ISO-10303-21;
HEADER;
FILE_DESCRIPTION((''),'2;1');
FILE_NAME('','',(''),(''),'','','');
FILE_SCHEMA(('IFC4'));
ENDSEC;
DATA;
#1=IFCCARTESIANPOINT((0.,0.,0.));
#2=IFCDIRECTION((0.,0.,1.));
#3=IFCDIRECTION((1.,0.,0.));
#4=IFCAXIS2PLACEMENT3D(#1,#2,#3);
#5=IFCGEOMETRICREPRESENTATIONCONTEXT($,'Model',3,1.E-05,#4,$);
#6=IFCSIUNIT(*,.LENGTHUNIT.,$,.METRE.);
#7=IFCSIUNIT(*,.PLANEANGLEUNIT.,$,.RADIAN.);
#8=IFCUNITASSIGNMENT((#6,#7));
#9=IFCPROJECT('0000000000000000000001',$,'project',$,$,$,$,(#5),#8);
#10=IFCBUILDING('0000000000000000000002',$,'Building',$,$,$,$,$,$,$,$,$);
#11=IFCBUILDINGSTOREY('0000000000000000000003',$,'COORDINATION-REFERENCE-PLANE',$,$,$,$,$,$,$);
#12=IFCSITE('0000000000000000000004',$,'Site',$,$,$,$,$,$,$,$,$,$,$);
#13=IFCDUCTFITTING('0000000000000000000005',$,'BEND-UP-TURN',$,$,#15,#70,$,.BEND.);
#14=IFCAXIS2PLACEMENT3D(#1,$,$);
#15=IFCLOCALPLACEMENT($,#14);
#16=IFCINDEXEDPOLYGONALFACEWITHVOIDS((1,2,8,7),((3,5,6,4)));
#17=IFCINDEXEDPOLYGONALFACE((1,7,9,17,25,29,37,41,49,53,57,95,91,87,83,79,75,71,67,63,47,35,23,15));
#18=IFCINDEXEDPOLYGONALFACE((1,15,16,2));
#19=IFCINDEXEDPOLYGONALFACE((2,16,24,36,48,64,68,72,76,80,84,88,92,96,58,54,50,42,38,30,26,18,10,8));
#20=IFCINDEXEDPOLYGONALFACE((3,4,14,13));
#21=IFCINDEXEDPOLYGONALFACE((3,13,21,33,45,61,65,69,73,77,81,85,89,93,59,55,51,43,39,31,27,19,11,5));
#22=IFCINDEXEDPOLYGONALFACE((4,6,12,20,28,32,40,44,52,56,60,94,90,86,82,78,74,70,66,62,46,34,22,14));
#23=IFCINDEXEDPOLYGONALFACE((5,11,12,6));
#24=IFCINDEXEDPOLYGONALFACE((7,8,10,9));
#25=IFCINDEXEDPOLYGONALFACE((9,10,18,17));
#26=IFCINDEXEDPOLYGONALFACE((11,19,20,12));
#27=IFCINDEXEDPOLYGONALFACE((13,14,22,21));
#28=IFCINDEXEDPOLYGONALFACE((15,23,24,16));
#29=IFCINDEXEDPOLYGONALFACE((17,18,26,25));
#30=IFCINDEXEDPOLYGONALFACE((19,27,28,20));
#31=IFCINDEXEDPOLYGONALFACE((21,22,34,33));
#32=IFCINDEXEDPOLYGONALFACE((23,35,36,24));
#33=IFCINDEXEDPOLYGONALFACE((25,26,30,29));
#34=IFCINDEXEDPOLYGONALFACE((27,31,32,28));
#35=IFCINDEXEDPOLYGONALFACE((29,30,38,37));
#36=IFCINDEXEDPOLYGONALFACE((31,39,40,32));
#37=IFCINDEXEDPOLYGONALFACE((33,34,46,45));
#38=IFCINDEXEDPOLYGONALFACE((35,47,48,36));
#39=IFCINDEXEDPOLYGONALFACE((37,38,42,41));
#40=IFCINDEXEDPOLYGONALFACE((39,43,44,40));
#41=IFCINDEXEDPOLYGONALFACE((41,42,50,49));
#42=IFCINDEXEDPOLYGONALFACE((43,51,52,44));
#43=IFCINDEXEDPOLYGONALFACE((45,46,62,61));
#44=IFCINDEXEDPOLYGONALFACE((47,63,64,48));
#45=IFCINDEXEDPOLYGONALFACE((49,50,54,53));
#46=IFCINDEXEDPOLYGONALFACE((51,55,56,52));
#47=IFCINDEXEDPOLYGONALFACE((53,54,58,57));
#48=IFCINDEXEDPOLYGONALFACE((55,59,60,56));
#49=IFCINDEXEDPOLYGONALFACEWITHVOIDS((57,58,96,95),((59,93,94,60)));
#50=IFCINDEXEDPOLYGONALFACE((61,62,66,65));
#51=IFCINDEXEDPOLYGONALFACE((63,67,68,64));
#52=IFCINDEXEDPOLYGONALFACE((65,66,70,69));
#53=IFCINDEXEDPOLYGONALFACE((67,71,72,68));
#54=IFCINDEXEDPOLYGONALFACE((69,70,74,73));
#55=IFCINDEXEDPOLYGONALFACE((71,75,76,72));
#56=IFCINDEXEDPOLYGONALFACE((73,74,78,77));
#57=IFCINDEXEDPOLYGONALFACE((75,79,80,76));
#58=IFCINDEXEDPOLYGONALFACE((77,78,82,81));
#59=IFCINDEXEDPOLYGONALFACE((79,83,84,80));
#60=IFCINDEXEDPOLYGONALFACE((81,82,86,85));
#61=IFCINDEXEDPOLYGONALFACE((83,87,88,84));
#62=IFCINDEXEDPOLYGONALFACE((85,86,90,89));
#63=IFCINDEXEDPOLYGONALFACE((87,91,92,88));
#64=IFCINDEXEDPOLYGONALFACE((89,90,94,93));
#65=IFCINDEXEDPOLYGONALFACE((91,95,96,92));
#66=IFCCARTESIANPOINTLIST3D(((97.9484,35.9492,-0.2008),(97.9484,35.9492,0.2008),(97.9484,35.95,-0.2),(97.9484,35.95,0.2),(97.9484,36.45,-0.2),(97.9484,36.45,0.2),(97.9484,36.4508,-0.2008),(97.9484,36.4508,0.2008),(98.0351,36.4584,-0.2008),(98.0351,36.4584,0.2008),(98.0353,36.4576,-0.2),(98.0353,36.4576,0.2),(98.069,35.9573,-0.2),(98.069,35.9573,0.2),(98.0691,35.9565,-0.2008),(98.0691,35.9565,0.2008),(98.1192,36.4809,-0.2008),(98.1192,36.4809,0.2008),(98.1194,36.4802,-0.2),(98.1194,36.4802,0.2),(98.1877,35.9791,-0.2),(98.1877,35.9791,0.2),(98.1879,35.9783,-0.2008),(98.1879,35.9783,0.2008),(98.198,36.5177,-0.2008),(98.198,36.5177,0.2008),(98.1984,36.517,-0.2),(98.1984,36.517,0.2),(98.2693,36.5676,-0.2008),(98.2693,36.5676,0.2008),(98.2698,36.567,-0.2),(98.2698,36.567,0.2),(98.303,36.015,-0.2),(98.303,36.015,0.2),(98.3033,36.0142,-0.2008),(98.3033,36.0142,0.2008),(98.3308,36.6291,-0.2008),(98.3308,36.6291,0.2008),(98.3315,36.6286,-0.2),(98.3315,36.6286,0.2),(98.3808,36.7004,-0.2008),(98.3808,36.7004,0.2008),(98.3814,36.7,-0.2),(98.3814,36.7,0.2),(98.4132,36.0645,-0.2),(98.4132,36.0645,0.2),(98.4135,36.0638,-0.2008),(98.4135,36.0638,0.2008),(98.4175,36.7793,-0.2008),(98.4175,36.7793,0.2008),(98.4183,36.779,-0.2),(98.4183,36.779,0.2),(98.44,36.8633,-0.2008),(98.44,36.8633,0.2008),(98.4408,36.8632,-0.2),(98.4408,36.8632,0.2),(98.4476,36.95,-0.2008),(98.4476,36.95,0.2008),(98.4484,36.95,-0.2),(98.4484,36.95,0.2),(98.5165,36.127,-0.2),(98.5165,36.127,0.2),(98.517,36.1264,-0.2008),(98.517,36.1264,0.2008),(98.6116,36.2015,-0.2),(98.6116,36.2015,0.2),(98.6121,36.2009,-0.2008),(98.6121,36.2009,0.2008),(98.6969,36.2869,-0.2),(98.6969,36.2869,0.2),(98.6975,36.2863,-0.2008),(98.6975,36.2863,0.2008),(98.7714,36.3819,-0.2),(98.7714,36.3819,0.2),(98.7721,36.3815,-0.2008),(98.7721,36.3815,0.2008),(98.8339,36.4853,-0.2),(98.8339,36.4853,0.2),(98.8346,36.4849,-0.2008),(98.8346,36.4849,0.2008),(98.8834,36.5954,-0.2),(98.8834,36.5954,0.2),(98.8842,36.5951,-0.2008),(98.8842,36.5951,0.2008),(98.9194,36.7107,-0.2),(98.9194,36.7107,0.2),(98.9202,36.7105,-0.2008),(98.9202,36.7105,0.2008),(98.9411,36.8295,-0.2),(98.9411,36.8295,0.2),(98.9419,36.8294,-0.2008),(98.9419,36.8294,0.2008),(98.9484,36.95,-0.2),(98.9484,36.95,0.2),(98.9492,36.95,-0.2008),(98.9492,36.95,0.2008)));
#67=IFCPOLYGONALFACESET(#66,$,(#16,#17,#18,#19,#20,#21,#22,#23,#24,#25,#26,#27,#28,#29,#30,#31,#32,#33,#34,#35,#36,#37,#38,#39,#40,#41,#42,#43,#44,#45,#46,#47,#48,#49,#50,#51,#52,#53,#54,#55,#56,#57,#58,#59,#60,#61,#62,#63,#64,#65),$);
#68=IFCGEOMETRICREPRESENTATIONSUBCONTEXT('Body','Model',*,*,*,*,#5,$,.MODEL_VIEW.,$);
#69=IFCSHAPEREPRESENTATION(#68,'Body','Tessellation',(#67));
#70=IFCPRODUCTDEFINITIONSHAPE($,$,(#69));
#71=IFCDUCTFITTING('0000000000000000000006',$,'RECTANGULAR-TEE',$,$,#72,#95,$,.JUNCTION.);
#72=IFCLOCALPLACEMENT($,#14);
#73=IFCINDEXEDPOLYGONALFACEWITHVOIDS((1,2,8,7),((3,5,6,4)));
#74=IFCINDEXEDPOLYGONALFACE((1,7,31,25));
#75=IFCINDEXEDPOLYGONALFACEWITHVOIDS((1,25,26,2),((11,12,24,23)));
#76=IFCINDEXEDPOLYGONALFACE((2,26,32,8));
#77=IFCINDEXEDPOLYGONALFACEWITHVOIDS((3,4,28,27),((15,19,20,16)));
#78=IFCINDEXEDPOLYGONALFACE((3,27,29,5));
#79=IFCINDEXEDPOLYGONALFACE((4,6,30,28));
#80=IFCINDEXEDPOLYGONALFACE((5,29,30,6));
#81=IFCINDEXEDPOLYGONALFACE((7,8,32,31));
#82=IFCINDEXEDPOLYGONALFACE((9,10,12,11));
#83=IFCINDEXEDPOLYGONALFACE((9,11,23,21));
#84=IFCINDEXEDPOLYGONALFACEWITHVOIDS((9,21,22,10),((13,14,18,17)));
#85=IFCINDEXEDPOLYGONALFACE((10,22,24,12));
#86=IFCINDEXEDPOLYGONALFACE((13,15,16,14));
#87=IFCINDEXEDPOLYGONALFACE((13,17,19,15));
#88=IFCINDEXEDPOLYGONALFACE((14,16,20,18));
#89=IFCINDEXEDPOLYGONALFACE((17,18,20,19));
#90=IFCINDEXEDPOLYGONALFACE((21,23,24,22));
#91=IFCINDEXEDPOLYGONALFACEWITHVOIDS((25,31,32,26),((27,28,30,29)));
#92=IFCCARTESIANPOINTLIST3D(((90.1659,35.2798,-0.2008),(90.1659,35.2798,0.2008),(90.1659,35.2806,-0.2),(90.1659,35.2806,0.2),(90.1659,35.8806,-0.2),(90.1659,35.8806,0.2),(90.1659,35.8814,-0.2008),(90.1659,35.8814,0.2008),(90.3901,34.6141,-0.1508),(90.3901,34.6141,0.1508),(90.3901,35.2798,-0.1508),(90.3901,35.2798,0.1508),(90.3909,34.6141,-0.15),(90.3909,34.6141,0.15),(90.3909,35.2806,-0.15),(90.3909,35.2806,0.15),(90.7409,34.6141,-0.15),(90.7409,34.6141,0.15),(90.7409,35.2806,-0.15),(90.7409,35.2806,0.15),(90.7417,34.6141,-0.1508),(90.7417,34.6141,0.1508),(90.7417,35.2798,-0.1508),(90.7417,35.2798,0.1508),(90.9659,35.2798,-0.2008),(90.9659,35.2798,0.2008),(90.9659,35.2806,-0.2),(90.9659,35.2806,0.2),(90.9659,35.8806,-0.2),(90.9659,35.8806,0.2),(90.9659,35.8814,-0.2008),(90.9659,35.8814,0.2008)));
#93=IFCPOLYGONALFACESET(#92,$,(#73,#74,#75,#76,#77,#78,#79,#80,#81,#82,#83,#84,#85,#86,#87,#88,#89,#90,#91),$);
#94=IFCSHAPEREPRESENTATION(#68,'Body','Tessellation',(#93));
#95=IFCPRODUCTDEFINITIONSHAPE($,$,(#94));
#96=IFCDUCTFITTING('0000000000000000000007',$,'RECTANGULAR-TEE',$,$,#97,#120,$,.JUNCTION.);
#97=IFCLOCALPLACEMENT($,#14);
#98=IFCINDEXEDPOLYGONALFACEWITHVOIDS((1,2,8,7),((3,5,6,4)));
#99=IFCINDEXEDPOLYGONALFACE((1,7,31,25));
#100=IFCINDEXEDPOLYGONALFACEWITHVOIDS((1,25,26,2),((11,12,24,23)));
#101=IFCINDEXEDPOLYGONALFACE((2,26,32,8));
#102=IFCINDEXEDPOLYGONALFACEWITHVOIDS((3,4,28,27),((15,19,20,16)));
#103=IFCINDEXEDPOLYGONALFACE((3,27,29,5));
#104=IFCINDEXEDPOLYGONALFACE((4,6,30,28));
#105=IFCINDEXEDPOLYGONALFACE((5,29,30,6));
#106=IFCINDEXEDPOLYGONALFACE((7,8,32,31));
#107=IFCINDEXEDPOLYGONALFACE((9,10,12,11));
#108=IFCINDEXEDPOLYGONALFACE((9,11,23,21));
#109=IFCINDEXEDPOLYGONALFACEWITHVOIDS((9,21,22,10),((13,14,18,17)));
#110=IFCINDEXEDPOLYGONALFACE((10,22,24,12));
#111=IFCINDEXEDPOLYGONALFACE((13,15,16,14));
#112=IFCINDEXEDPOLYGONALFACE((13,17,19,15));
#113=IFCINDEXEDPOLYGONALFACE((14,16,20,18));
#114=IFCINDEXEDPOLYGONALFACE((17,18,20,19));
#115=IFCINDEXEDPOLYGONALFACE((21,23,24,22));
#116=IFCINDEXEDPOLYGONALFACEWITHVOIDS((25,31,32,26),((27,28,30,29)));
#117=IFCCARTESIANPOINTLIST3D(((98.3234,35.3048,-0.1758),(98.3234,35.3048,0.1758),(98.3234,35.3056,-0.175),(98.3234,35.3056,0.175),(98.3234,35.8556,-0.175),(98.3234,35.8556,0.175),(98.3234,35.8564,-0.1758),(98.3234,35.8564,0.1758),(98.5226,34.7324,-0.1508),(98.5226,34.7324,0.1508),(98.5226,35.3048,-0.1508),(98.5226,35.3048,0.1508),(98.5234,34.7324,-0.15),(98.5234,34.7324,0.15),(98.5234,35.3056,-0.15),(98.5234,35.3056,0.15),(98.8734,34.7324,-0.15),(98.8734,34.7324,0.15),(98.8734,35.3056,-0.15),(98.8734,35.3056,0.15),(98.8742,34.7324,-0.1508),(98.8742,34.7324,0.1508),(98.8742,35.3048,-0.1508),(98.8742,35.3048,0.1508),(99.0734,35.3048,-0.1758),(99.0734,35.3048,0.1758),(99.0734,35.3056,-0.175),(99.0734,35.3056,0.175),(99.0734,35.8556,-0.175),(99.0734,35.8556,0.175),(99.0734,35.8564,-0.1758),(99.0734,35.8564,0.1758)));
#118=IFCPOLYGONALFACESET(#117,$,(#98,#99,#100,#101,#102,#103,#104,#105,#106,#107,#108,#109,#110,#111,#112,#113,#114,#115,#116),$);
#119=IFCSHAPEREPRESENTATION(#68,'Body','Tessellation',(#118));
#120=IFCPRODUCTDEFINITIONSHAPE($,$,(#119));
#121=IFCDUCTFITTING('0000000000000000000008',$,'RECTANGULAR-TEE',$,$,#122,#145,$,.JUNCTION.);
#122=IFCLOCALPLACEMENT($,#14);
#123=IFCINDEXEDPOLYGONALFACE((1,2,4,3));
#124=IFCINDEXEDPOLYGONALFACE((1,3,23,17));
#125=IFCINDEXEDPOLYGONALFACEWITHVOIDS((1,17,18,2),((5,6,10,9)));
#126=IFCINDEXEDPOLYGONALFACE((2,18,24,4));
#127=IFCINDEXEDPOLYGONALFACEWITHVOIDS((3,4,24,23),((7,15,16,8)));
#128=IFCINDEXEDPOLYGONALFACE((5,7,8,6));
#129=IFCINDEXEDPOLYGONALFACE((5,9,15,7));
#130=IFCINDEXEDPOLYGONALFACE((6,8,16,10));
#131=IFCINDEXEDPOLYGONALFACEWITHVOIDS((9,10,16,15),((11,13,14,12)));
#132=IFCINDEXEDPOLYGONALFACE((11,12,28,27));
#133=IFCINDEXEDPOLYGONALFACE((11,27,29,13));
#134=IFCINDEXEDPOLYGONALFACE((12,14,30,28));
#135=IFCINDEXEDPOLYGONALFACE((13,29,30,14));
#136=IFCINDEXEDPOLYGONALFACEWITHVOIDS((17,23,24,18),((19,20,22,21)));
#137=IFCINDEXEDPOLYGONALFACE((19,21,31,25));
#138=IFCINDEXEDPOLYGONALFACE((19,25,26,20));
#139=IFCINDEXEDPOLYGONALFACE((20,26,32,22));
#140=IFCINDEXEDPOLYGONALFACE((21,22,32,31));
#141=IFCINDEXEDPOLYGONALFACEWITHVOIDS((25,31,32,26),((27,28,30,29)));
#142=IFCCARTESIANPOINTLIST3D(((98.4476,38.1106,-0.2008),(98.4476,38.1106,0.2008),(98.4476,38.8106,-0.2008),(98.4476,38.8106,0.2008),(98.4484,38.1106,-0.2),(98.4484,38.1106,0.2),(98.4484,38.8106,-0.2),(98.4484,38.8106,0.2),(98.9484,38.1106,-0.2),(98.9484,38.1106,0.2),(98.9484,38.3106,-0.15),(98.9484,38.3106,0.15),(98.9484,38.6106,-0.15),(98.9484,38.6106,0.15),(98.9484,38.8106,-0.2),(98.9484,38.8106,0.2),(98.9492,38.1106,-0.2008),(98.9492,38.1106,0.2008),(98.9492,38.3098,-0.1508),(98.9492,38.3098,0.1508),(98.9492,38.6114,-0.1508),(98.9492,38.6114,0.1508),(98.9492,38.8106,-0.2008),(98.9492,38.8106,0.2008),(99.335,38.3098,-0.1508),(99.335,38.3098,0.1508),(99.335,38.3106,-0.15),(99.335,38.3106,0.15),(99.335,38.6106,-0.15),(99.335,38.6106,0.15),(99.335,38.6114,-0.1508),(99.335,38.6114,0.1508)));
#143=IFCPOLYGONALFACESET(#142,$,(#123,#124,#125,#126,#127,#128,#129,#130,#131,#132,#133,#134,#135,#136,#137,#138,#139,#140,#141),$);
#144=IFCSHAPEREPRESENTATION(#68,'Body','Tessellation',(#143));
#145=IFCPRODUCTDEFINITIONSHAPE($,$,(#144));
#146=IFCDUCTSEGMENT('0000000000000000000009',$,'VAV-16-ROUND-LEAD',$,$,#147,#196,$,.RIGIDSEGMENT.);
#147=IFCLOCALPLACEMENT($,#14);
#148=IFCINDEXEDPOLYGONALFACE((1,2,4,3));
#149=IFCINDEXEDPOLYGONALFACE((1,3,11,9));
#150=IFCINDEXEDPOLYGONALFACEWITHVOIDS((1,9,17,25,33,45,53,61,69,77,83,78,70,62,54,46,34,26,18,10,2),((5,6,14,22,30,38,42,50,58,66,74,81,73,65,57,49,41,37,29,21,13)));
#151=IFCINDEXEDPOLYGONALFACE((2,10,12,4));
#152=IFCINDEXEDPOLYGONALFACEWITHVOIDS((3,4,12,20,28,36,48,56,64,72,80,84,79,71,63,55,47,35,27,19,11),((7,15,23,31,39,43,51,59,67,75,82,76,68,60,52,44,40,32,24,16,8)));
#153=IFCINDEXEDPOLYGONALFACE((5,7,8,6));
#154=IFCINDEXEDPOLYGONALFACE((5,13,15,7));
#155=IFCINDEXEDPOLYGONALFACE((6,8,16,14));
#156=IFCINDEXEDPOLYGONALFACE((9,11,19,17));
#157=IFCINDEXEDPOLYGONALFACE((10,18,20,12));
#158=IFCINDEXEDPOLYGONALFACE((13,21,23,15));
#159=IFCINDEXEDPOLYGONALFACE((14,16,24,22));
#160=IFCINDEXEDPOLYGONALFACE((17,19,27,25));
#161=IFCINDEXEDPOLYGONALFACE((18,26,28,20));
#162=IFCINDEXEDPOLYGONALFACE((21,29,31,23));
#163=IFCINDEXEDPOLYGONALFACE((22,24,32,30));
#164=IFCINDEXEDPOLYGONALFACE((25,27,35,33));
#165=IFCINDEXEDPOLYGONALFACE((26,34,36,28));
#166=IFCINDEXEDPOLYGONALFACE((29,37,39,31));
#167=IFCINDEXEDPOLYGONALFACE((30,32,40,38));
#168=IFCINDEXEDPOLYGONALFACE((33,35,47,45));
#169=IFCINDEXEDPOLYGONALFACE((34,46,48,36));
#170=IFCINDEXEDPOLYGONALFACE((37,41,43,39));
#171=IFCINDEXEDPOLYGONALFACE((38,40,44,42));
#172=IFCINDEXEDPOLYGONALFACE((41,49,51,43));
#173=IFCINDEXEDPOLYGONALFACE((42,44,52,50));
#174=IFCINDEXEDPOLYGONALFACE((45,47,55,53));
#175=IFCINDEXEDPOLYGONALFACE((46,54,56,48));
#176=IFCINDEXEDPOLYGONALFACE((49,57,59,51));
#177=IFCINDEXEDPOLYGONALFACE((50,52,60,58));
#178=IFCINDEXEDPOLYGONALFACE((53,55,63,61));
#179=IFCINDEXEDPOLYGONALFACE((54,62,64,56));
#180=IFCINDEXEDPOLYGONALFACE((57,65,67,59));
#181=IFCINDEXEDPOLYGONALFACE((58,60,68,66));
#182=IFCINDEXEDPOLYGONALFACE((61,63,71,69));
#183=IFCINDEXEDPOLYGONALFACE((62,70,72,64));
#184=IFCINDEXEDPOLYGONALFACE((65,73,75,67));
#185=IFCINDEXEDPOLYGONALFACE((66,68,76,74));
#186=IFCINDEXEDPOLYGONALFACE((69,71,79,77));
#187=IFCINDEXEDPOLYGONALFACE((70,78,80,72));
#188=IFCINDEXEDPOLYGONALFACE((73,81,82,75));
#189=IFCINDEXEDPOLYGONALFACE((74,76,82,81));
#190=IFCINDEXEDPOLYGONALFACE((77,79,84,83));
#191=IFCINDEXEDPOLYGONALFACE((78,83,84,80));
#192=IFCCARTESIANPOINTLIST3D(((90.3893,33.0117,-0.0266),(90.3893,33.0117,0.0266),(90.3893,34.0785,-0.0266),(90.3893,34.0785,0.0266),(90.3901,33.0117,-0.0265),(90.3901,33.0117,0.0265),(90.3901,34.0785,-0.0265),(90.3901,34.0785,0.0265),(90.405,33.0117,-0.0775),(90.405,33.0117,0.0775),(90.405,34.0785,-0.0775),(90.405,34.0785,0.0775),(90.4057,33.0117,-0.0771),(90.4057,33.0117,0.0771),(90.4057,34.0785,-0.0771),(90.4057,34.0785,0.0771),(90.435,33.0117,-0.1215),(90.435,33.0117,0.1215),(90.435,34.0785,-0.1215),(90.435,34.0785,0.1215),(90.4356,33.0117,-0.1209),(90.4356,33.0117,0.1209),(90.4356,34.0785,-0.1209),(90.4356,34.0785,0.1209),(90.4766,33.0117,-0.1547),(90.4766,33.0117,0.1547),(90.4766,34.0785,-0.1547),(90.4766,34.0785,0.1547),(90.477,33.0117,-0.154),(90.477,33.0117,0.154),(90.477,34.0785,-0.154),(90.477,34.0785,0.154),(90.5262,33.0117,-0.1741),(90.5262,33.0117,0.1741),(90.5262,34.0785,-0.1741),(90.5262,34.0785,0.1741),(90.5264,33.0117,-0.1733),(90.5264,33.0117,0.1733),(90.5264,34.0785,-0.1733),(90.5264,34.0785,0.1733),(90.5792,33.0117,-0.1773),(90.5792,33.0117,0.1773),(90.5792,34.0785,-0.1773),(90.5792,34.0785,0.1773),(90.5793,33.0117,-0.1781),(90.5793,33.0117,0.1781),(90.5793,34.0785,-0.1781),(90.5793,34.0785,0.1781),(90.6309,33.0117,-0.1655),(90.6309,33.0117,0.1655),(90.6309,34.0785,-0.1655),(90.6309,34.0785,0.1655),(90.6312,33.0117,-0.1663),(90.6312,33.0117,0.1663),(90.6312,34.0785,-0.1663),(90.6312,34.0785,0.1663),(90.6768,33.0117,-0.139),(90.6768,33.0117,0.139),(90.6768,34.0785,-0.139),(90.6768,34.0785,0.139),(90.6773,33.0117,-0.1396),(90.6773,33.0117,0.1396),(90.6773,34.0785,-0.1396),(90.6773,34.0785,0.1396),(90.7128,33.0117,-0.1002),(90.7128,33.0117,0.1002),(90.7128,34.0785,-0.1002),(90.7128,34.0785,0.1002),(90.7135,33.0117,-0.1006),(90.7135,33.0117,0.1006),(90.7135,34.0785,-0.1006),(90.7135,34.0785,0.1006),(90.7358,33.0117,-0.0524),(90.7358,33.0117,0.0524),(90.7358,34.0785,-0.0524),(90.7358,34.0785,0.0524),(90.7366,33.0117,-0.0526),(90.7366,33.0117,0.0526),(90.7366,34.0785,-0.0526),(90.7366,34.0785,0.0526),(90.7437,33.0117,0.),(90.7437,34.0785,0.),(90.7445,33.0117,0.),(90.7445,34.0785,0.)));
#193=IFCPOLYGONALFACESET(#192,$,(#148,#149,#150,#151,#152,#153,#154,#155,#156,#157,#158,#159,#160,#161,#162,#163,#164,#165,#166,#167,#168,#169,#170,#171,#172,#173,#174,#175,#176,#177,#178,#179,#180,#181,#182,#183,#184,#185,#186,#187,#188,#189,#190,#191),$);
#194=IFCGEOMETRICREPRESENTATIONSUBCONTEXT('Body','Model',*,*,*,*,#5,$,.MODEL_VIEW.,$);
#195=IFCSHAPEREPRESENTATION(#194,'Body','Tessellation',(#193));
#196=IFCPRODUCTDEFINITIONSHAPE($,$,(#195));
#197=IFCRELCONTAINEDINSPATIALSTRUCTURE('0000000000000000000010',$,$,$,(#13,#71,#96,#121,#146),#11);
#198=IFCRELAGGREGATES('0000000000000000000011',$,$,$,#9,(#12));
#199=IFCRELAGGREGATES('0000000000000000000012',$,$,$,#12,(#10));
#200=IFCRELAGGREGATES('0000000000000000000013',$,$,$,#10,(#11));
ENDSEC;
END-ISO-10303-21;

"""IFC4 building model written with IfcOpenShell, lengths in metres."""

from ifc_helpers import new_model, entity, si_unit, frame, origin, origin_with_axes, place, context, subcontext, project, spatial, rectangle, hollow_circle, extrude, boolean, element, save


model = new_model("IFC4")

# Units and contexts
model_context = context("Model", 3, precision=1e-05, world=origin_with_axes())
body_context_1 = subcontext(model_context, "Body", "Model", "MODEL_VIEW")
body_context_2 = subcontext(model_context, "Body", "Model", "MODEL_VIEW")
ifc_project = project(units=[si_unit("LENGTHUNIT", "METRE"), si_unit("PLANEANGLEUNIT", "RADIAN")], contexts=[model_context])

# Site, building, storey
site = spatial("IfcSite", under=ifc_project, Name="Site")
building = spatial("IfcBuilding", under=site, Name="Building")
storey = spatial("IfcBuildingStorey", under=building, Name="COORDINATION-REFERENCE-PLANE")

# Duct fittings
duct_fitting_1_placement = place(None, frame((97.9484, 36.95, 0.0), z_axis=(0.0, 0.0, 1.0), x_axis=(0.0, -1.0, 0.0)))
cartesian_point_1 = entity("IfcCartesianPoint", [0.0, 0.0, 0.0])
element("IfcDuctFitting", 1, at=duct_fitting_1_placement, inside=storey, Name="BEND-UP-TURN", PredefinedType="BEND", context=body_context_1, shape_type="SweptSolid", body=[
    entity("IfcRevolvedAreaSolid", entity("IfcRectangleHollowProfileDef", "AREA", None, entity("IfcAxis2Placement2D", entity("IfcCartesianPoint", [0.75, 0.0])), 0.5016, 0.4016, 0.0008), entity("IfcAxis2Placement3D", cartesian_point_1, entity("IfcDirection", [0.0, -1.0, 0.0]), entity("IfcDirection", [1.0, 0.0, 0.0])), entity("IfcAxis1Placement", cartesian_point_1, entity("IfcDirection", [0.0, 1.0, 0.0])), 1.570796),
])
duct_fitting_2_placement = place(None, frame((90.5659, 35.5806, 0.0), z_axis=(1.0, 0.0, 0.0), x_axis=(0.0, -1.0, 0.0)))
solid_1 = boolean("UNION", extrude(rectangle(XDim=0.6, YDim=0.4), frame((0.0, 0.0, -0.4), z_axis=(0.0, 0.0, 1.0), x_axis=(1.0, 0.0, 0.0)), (0.0, 0.0, 1.0), 0.8), extrude(rectangle(XDim=0.35, YDim=0.3), frame((0.0, 0.0, 0.0), z_axis=(1.0, 0.0, 0.0), x_axis=(0.0, 0.0, -1.0)), (0.0, 0.0, 1.0), 0.9665))
element("IfcDuctFitting", 2, at=duct_fitting_2_placement, inside=storey, Name="RECTANGULAR-TEE", PredefinedType="JUNCTION", context=body_context_1, shape_type="CSG", body=[
    boolean("DIFFERENCE", boolean("UNION", extrude(rectangle(XDim=0.6016, YDim=0.4016), frame((0.0, 0.0, -0.4), z_axis=(0.0, 0.0, 1.0), x_axis=(1.0, 0.0, 0.0)), (0.0, 0.0, 1.0), 0.8), extrude(rectangle(XDim=0.3516, YDim=0.3016), frame((0.0, 0.0, 0.0), z_axis=(1.0, 0.0, 0.0), x_axis=(0.0, 0.0, -1.0)), (0.0, 0.0, 1.0), 0.9665)), solid_1),
])
duct_fitting_3_placement = place(None, frame((98.6984, 35.5806, 0.0), z_axis=(1.0, 0.0, 0.0), x_axis=(0.0, -1.0, 0.0)))
solid_2 = boolean("UNION", extrude(rectangle(XDim=0.55, YDim=0.35), frame((0.0, 0.0, -0.375), z_axis=(0.0, 0.0, 1.0), x_axis=(1.0, 0.0, 0.0)), (0.0, 0.0, 1.0), 0.75), extrude(rectangle(XDim=0.35, YDim=0.3), frame((0.0, 0.0, 0.0), z_axis=(1.0, 0.0, 0.0), x_axis=(0.0, 0.0, -1.0)), (0.0, 0.0, 1.0), 0.8482))
element("IfcDuctFitting", 3, at=duct_fitting_3_placement, inside=storey, Name="RECTANGULAR-TEE", PredefinedType="JUNCTION", context=body_context_1, shape_type="CSG", body=[
    boolean("DIFFERENCE", boolean("UNION", extrude(rectangle(XDim=0.5516, YDim=0.3516), frame((0.0, 0.0, -0.375), z_axis=(0.0, 0.0, 1.0), x_axis=(1.0, 0.0, 0.0)), (0.0, 0.0, 1.0), 0.75), extrude(rectangle(XDim=0.3516, YDim=0.3016), frame((0.0, 0.0, 0.0), z_axis=(1.0, 0.0, 0.0), x_axis=(0.0, 0.0, -1.0)), (0.0, 0.0, 1.0), 0.8482)), solid_2),
])
duct_fitting_4_placement = place(None, frame((98.6984, 38.4606, 0.0), z_axis=(0.0, 1.0, 0.0), x_axis=(1.0, 0.0, 0.0)))
solid_3 = boolean("UNION", extrude(rectangle(XDim=0.5, YDim=0.4), frame((0.0, 0.0, -0.35), z_axis=(0.0, 0.0, 1.0), x_axis=(1.0, 0.0, 0.0)), (0.0, 0.0, 1.0), 0.7), extrude(rectangle(XDim=0.3, YDim=0.3), frame((0.0, 0.0, 0.0), z_axis=(1.0, 0.0, 0.0), x_axis=(0.0, 0.0, -1.0)), (0.0, 0.0, 1.0), 0.6366))
element("IfcDuctFitting", 4, at=duct_fitting_4_placement, inside=storey, Name="RECTANGULAR-TEE", PredefinedType="JUNCTION", context=body_context_1, shape_type="CSG", body=[
    boolean("DIFFERENCE", boolean("UNION", extrude(rectangle(XDim=0.5016, YDim=0.4016), frame((0.0, 0.0, -0.35), z_axis=(0.0, 0.0, 1.0), x_axis=(1.0, 0.0, 0.0)), (0.0, 0.0, 1.0), 0.7), extrude(rectangle(XDim=0.3016, YDim=0.3016), frame((0.0, 0.0, 0.0), z_axis=(1.0, 0.0, 0.0), x_axis=(0.0, 0.0, -1.0)), (0.0, 0.0, 1.0), 0.6366)), solid_3),
])

# Duct segment
for number, where, z_axis, x_axis, name in (
    (5, (90.5659, 34.0785, 0.0), (0.0, -1.0, 0.0), (1.0, 0.0, 0.0), "VAV-16-ROUND-LEAD"),
):
    element("IfcDuctSegment", number, at=place(None, frame(where, z_axis=z_axis, x_axis=x_axis)), inside=storey, Name=name, PredefinedType="RIGIDSEGMENT", context=body_context_2, shape_type="SweptSolid", body=[
        extrude(hollow_circle(Radius=0.1786, WallThickness=0.0008), origin(), (0.0, 0.0, 1.0), 1.0668),
    ])

save(model, "model.ifc")
